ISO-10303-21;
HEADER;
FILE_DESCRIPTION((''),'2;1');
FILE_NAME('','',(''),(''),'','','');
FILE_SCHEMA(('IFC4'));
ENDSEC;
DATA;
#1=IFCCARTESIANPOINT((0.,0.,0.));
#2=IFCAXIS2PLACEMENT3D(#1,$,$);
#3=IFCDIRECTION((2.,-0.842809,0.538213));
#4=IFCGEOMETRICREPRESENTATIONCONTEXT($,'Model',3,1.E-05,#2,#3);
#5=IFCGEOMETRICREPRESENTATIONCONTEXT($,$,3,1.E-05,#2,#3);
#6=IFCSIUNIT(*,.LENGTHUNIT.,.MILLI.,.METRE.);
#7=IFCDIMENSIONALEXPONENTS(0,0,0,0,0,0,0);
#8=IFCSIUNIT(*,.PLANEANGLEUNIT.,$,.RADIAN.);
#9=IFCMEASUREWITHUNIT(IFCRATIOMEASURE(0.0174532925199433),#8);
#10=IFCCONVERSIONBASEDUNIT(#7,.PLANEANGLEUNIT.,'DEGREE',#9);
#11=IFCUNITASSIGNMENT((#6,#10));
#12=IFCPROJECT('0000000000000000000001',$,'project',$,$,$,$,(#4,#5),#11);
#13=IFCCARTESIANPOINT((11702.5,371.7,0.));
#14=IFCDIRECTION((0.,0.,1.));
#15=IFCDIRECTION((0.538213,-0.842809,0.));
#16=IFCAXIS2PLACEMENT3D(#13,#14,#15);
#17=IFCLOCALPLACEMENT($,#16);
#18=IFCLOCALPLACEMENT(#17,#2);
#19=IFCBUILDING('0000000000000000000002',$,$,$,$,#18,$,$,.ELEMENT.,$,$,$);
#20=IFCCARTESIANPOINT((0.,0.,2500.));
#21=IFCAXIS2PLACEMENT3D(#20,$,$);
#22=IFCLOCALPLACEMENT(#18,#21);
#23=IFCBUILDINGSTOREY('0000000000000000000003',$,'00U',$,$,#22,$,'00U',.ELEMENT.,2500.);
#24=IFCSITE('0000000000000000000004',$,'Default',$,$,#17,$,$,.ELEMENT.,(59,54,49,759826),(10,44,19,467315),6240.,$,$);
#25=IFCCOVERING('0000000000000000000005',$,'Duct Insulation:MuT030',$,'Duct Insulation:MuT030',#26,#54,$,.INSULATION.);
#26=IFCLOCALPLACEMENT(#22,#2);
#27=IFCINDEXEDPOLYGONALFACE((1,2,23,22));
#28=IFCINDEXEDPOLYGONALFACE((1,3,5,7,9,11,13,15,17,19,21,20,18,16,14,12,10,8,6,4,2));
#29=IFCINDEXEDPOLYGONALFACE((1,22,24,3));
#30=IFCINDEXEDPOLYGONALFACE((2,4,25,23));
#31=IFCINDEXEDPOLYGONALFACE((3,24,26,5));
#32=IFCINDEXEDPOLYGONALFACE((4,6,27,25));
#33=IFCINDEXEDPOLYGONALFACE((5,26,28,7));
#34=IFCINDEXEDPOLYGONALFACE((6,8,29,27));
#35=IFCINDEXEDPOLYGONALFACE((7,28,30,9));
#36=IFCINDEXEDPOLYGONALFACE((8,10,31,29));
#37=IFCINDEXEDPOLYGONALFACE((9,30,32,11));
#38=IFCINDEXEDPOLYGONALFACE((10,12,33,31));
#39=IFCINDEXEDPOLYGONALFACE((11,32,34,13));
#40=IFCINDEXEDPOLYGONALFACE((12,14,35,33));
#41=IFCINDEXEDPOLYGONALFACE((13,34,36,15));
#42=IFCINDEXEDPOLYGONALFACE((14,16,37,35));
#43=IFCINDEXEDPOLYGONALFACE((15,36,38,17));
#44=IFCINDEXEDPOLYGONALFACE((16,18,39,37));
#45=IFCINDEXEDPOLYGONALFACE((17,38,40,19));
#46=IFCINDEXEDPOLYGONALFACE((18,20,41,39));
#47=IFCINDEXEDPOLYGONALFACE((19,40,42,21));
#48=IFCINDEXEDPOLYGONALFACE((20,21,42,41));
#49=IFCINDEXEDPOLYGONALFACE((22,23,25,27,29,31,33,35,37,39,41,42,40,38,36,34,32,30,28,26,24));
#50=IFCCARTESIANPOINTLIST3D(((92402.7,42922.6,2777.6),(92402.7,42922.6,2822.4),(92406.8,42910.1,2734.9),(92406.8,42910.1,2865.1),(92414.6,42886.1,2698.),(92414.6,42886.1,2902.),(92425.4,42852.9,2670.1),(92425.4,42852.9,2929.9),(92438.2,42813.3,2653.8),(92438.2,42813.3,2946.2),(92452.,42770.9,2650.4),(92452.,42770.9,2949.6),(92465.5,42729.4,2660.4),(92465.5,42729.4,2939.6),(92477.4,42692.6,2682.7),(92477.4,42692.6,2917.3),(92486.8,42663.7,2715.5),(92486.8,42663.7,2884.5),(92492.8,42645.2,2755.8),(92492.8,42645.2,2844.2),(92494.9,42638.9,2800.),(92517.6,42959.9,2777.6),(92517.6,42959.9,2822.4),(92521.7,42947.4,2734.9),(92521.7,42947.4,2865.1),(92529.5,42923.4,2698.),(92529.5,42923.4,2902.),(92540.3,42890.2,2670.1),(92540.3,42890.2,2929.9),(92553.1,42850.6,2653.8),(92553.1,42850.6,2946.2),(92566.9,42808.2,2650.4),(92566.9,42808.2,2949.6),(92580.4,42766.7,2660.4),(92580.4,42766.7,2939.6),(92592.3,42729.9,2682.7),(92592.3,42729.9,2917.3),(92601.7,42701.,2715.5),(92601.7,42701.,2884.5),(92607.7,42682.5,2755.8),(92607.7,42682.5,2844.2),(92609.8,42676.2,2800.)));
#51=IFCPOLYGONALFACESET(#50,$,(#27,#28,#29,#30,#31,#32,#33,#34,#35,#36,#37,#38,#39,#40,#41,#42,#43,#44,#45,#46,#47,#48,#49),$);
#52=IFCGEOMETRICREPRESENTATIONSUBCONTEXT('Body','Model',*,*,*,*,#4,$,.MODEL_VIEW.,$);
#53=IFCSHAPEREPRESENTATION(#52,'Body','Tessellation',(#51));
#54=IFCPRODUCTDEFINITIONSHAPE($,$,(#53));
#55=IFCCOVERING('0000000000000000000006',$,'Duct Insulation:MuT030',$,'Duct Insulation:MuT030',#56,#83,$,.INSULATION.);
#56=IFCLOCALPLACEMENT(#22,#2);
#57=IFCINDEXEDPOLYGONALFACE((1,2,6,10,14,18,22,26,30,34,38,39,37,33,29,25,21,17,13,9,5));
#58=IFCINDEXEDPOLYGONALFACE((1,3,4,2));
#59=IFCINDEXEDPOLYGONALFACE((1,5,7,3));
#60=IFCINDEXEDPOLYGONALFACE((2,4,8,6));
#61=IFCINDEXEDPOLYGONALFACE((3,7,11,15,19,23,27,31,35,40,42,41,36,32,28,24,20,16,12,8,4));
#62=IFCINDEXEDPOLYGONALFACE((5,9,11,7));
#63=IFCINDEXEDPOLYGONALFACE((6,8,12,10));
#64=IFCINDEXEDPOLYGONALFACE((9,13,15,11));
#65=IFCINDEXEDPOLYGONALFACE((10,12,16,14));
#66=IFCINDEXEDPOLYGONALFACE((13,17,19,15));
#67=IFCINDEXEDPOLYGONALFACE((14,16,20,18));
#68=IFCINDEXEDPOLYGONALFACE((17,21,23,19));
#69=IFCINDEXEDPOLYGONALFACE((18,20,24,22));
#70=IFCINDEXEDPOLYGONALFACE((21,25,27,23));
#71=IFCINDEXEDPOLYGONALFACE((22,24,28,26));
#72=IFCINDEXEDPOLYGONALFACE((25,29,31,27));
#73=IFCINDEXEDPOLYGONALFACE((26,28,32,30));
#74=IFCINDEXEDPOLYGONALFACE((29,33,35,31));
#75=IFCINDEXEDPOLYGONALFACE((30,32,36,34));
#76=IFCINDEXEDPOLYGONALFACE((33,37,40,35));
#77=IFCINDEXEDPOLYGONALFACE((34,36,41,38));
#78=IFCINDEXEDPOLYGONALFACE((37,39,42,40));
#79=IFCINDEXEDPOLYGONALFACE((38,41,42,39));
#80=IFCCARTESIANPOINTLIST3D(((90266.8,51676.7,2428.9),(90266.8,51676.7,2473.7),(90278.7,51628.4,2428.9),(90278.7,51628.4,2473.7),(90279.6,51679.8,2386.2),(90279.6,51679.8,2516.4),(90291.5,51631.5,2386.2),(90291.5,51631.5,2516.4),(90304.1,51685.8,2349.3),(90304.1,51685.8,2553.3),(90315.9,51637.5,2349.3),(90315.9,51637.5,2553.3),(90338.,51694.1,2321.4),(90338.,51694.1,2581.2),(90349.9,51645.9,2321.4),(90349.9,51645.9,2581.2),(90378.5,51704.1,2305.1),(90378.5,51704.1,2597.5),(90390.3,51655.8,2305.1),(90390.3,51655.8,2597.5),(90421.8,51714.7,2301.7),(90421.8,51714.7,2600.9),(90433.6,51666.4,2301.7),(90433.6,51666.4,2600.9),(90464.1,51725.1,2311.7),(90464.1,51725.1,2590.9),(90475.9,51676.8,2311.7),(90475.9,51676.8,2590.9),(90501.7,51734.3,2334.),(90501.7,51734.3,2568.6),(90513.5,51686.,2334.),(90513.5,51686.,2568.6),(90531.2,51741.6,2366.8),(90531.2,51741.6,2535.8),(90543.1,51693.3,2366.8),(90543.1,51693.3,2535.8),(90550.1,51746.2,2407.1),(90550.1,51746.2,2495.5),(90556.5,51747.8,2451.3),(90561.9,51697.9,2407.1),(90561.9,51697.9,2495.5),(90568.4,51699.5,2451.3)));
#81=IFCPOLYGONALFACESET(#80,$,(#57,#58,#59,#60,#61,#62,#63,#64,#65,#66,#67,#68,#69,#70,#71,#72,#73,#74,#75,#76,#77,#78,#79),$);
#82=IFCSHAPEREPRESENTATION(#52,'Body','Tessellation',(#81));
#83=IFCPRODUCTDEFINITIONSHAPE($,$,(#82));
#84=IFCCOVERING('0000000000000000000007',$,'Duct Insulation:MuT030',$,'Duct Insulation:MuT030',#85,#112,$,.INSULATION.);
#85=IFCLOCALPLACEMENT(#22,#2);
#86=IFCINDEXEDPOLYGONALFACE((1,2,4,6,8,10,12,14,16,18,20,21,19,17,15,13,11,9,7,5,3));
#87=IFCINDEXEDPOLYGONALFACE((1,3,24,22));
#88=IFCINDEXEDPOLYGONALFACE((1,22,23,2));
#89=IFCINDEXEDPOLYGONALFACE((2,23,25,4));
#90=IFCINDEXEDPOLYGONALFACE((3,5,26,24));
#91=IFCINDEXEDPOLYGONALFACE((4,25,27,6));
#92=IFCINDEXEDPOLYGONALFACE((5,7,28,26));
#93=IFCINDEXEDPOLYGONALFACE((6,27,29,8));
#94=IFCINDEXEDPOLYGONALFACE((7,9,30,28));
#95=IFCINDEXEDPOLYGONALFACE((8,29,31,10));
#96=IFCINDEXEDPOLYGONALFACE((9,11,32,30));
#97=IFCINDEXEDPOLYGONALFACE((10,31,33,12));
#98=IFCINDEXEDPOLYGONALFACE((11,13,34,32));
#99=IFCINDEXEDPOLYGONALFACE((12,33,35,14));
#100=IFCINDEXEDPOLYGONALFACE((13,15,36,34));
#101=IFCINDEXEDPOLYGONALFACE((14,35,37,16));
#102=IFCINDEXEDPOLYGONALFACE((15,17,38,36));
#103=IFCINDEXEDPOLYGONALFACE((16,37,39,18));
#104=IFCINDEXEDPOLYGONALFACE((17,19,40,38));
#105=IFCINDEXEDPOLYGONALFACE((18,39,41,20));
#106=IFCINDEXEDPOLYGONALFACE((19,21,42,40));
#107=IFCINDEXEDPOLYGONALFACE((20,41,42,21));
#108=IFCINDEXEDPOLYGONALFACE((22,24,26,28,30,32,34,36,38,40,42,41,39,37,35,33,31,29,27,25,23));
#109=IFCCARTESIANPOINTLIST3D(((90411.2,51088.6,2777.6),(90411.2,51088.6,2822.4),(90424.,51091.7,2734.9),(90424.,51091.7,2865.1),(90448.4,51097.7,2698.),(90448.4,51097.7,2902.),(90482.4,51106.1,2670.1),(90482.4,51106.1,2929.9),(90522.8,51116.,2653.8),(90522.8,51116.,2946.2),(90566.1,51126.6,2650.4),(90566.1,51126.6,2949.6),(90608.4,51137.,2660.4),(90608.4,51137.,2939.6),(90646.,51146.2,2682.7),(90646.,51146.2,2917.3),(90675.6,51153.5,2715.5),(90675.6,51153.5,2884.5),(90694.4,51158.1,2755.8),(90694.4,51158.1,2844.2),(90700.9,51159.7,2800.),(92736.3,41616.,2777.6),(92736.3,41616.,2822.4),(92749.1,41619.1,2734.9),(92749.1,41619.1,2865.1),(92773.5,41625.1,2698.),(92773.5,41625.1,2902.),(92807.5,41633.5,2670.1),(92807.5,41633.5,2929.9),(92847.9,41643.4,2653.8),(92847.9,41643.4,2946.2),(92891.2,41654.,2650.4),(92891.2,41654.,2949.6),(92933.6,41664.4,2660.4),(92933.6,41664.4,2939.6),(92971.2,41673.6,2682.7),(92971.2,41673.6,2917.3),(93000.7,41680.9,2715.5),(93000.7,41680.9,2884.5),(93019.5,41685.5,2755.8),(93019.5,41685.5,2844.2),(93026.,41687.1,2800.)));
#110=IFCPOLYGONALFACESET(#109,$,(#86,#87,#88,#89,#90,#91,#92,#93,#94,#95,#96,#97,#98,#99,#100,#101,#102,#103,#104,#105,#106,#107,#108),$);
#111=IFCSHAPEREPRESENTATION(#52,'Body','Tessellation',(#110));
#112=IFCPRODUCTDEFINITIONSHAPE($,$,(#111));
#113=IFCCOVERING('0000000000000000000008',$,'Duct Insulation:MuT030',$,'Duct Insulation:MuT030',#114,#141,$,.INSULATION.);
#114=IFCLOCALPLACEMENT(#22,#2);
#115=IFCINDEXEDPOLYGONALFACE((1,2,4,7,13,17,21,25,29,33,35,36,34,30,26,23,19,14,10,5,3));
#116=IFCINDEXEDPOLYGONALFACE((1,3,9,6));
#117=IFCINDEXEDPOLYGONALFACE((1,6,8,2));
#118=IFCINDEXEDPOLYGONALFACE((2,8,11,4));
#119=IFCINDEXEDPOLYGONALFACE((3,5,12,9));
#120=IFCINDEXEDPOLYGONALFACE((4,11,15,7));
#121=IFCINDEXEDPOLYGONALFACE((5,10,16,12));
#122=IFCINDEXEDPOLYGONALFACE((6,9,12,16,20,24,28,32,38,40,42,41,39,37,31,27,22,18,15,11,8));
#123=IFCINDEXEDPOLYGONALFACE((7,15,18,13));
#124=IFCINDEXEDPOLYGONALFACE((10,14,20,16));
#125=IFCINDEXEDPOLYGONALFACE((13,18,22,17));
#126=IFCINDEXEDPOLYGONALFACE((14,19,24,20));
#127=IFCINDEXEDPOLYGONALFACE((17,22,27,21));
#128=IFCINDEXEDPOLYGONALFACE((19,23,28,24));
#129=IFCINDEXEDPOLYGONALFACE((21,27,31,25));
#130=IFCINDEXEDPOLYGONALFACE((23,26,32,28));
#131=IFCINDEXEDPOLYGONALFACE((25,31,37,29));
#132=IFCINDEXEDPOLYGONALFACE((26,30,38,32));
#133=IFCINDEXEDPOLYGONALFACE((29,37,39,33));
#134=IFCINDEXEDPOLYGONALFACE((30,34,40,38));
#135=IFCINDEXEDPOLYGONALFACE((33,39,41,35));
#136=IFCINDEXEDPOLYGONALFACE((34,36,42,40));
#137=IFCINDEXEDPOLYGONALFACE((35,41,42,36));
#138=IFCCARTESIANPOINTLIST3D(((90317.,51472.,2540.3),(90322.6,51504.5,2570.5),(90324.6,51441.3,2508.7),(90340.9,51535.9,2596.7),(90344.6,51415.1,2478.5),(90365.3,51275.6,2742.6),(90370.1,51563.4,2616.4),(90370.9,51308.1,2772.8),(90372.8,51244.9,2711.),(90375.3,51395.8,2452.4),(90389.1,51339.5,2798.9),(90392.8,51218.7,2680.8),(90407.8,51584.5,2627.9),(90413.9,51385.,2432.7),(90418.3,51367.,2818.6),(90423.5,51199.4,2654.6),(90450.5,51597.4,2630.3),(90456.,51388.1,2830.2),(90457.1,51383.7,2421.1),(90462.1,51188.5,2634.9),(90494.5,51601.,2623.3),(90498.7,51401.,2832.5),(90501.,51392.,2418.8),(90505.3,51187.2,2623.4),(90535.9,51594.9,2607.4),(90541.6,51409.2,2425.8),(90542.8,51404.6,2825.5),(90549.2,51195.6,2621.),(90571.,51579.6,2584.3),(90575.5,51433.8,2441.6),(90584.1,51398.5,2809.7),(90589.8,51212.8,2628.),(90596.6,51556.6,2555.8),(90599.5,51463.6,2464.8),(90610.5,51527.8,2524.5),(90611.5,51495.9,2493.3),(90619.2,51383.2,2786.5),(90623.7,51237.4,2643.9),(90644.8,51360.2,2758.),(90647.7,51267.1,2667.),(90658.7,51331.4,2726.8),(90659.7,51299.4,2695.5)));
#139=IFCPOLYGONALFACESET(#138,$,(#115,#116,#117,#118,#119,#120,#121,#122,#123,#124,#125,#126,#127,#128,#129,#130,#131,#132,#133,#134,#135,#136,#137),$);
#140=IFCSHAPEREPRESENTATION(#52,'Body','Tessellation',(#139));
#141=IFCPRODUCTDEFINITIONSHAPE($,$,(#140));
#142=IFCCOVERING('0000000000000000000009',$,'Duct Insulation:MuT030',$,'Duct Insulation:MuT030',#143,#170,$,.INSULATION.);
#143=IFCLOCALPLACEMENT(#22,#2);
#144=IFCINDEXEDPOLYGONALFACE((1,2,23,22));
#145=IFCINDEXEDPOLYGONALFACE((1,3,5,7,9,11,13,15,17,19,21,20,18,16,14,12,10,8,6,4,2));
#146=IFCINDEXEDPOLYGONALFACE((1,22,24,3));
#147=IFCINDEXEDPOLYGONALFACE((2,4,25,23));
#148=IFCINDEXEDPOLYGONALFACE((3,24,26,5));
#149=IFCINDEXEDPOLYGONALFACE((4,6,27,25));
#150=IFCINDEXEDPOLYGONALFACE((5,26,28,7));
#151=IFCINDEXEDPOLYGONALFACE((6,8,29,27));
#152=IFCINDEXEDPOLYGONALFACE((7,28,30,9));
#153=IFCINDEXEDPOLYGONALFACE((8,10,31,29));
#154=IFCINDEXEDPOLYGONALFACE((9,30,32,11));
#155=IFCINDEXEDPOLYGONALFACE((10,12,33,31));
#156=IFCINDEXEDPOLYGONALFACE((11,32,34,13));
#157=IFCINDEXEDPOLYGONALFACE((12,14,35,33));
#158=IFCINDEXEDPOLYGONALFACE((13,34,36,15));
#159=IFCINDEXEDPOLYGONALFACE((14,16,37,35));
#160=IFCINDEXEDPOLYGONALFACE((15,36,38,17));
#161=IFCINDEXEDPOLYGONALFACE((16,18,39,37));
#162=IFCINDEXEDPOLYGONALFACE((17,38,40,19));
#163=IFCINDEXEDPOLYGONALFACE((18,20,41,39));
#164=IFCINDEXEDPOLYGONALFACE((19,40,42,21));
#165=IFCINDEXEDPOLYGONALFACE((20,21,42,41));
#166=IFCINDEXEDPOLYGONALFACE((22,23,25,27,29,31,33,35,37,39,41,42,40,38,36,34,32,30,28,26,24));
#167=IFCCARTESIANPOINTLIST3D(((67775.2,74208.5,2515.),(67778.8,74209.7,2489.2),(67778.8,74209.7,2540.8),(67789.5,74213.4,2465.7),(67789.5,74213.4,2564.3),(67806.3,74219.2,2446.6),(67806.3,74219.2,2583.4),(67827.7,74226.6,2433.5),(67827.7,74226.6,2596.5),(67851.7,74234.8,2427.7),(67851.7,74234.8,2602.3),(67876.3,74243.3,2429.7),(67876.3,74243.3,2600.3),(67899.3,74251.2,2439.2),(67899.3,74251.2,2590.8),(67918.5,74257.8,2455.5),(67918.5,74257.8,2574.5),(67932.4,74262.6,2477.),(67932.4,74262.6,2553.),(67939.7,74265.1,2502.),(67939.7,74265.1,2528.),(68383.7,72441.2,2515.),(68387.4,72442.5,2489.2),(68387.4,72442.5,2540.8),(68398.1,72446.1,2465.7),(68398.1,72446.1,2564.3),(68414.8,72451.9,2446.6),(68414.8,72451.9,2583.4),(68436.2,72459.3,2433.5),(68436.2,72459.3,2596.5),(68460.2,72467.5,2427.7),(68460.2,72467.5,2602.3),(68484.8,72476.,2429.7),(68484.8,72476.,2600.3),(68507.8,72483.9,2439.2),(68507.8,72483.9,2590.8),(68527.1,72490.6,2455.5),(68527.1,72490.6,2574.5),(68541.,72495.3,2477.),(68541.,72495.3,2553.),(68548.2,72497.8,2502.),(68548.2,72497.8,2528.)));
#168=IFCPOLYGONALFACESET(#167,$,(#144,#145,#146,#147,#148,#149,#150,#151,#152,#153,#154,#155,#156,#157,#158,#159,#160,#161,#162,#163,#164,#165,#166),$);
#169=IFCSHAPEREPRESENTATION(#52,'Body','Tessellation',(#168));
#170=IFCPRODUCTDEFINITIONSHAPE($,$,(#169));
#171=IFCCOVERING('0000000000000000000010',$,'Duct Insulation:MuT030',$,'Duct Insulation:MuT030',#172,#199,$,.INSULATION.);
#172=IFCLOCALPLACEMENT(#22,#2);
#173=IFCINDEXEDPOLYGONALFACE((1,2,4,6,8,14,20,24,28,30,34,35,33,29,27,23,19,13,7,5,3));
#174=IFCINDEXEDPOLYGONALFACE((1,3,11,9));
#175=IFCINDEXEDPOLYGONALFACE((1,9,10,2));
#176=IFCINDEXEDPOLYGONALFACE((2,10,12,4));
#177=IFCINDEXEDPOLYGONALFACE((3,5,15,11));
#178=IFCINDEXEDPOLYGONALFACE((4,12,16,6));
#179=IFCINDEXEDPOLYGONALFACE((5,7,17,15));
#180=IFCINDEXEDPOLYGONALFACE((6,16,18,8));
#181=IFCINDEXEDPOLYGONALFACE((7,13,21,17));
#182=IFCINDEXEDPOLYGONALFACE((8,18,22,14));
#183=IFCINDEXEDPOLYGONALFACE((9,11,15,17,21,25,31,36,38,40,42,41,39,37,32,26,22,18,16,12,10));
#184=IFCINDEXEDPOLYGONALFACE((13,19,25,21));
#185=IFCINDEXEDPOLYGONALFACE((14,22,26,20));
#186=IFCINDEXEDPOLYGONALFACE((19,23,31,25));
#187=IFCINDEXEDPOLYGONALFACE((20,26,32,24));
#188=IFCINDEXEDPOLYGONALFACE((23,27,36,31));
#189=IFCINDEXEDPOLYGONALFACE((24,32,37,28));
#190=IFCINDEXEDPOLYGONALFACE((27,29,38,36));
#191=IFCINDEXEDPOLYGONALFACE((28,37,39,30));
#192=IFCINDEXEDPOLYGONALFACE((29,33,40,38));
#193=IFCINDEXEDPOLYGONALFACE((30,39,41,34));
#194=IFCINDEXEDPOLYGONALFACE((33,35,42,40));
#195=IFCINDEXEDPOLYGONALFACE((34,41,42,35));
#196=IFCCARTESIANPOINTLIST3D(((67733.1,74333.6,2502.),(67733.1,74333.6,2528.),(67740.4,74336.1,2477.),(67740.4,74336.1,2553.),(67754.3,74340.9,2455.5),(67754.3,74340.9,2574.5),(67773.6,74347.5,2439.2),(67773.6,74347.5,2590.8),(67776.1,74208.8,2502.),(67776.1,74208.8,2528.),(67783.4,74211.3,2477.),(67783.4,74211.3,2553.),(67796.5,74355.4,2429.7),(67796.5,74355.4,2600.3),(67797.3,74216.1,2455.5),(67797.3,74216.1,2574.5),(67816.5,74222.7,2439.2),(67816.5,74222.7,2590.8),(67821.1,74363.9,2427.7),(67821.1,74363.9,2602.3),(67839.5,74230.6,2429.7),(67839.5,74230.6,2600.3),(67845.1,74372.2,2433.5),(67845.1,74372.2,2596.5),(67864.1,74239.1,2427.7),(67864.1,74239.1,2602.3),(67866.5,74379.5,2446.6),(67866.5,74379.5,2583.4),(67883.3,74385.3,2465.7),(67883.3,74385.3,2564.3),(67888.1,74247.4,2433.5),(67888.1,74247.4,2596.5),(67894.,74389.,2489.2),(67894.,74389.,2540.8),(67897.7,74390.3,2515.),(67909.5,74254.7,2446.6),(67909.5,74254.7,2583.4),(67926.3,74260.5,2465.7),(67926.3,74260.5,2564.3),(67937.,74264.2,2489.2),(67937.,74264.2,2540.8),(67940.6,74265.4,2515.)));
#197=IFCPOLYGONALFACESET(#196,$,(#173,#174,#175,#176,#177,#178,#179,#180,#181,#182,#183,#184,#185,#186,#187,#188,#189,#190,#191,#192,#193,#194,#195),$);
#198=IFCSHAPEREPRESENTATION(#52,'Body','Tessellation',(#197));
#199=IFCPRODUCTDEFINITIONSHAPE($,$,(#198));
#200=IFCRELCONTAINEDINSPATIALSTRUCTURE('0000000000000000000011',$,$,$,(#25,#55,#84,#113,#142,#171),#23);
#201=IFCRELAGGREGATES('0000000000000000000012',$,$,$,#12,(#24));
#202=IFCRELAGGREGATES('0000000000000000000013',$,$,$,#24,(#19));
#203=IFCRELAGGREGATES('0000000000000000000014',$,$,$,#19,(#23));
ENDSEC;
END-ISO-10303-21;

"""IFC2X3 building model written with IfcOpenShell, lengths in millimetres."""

from ifc_helpers import new_model, entity, si_unit, converted_unit, direction, frame, frame_2d, origin, origin_2d_with_axis, place, context, subcontext, project, spatial, circle, extrude, element, save


model = new_model("IFC2X3")

# Units and contexts
model_context = context("Model", 3, precision=1e-05, world=origin(), true_north=direction((2.0, -0.842809, 0.538213)))
context_of_model = context(None, 3, precision=1e-05, world=origin(), true_north=direction((2.0, -0.842809, 0.538213)))
body_context = subcontext(model_context, "Body", "Model", "MODEL_VIEW")
ifc_project = project(units=[si_unit("LENGTHUNIT", "METRE", prefix="MILLI"), converted_unit("PLANEANGLEUNIT", "DEGREE", entity("IfcRatioMeasure", 0.0174532925199433), si_unit("PLANEANGLEUNIT", "RADIAN"), dimensions=[0, 0, 0, 0, 0, 0, 0])], contexts=[model_context, context_of_model])

# Site, building, storey
site_placement = place(None, frame((11702.5, 371.7, 0.0), z_axis=(0.0, 0.0, 1.0), x_axis=(0.538213, -0.842809, 0.0)))
site = spatial("IfcSite", under=ifc_project, at=site_placement, Name="Default", CompositionType="ELEMENT", RefLatitude=(59, 54, 49, 759826), RefLongitude=(10, 44, 19, 467315), RefElevation=6240.0)
building_placement = place(site_placement, origin())
building = spatial("IfcBuilding", under=site, at=building_placement, CompositionType="ELEMENT")
storey_placement = place(building_placement, frame((0.0, 0.0, 2500.0)))
storey = spatial("IfcBuildingStorey", under=building, at=storey_placement, Name="00U", LongName="00U", CompositionType="ELEMENT", Elevation=2500.0)

# Coverings
covering_1_placement = place(storey_placement, origin())
element("IfcCovering", 1, at=covering_1_placement, inside=storey, Name="Duct Insulation:MuT030", ObjectType="Duct Insulation:MuT030", PredefinedType="INSULATION", context=body_context, shape_type="SweptSolid", body=[
    extrude(circle(Radius=150.0, at=origin_2d_with_axis()), frame((92448.5, 42781.5, 2800.0), z_axis=(0.951057, 0.309017, 0.0), x_axis=(0.309017, -0.951057, 0.0)), (0.0, 0.0, 1.0), 120.8),
])
covering_2_placement = place(storey_placement, origin())
element("IfcCovering", 2, at=covering_2_placement, inside=storey, Name="Duct Insulation:MuT030", ObjectType="Duct Insulation:MuT030", PredefinedType="INSULATION", context=body_context, shape_type="SweptSolid", body=[
    extrude(circle(Radius=150.0, at=origin_2d_with_axis()), frame((90410.9, 51712.0, 2451.3), z_axis=(0.238381, -0.971172, 0.0), x_axis=(0.971172, 0.238381, 0.0)), (0.0, 0.0, 1.0), 49.7),
])
covering_3_placement = place(storey_placement, origin())
element("IfcCovering", 3, at=covering_3_placement, inside=storey, Name="Duct Insulation:MuT030", ObjectType="Duct Insulation:MuT030", PredefinedType="INSULATION", context=body_context, shape_type="SweptSolid", body=[
    extrude(circle(Radius=150.0, at=frame_2d((0.0, 0.0), x_axis=(1.0, 0.0))), frame((92880.3, 41651.3, 2800.0), z_axis=(-0.238381, 0.971172, 0.0), x_axis=(0.971172, 0.238381, 0.0)), (0.0, 0.0, 1.0), 9753.8),
])
covering_4_placement = place(storey_placement, origin())
element("IfcCovering", 4, at=covering_4_placement, inside=storey, Name="Duct Insulation:MuT030", ObjectType="Duct Insulation:MuT030", PredefinedType="INSULATION", context=body_context, shape_type="SweptSolid", body=[
    extrude(circle(Radius=150.0, at=frame_2d((0.0, 0.0), x_axis=(1.0, 0.0))), frame((90464.9, 51492.0, 2524.5), z_axis=(0.168561, -0.686722, 0.707107), x_axis=(0.971172, 0.238381, 0.0)), (0.0, 0.0, 1.0), 286.0),
])
covering_5_placement = place(storey_placement, origin())
element("IfcCovering", 5, at=covering_5_placement, inside=storey, Name="Duct Insulation:MuT030", ObjectType="Duct Insulation:MuT030", PredefinedType="INSULATION", context=body_context, shape_type="SweptSolid", body=[
    extrude(circle(Radius=87.5, at=frame_2d((0.0, 0.0), x_axis=(1.0, 0.0))), frame((68466.4, 72469.7, 2515.0), z_axis=(-0.325568, 0.945519, 0.0), x_axis=(-0.945519, -0.325568, 0.0)), (0.0, 0.0, 1.0), 1869.1),
])
covering_6_placement = place(storey_placement, origin())
element("IfcCovering", 6, at=covering_6_placement, inside=storey, Name="Duct Insulation:MuT030", ObjectType="Duct Insulation:MuT030", PredefinedType="INSULATION", context=body_context, shape_type="SweptSolid", body=[
    extrude(circle(Radius=87.5, at=frame_2d((0.0, 0.0), x_axis=(1.0, 0.0))), frame((67857.9, 74237.0, 2515.0), z_axis=(-0.325568, 0.945519, 0.0), x_axis=(0.945519, 0.325568, 0.0)), (0.0, 0.0, 1.0), 132.0),
])

save(model, "model.ifc")
